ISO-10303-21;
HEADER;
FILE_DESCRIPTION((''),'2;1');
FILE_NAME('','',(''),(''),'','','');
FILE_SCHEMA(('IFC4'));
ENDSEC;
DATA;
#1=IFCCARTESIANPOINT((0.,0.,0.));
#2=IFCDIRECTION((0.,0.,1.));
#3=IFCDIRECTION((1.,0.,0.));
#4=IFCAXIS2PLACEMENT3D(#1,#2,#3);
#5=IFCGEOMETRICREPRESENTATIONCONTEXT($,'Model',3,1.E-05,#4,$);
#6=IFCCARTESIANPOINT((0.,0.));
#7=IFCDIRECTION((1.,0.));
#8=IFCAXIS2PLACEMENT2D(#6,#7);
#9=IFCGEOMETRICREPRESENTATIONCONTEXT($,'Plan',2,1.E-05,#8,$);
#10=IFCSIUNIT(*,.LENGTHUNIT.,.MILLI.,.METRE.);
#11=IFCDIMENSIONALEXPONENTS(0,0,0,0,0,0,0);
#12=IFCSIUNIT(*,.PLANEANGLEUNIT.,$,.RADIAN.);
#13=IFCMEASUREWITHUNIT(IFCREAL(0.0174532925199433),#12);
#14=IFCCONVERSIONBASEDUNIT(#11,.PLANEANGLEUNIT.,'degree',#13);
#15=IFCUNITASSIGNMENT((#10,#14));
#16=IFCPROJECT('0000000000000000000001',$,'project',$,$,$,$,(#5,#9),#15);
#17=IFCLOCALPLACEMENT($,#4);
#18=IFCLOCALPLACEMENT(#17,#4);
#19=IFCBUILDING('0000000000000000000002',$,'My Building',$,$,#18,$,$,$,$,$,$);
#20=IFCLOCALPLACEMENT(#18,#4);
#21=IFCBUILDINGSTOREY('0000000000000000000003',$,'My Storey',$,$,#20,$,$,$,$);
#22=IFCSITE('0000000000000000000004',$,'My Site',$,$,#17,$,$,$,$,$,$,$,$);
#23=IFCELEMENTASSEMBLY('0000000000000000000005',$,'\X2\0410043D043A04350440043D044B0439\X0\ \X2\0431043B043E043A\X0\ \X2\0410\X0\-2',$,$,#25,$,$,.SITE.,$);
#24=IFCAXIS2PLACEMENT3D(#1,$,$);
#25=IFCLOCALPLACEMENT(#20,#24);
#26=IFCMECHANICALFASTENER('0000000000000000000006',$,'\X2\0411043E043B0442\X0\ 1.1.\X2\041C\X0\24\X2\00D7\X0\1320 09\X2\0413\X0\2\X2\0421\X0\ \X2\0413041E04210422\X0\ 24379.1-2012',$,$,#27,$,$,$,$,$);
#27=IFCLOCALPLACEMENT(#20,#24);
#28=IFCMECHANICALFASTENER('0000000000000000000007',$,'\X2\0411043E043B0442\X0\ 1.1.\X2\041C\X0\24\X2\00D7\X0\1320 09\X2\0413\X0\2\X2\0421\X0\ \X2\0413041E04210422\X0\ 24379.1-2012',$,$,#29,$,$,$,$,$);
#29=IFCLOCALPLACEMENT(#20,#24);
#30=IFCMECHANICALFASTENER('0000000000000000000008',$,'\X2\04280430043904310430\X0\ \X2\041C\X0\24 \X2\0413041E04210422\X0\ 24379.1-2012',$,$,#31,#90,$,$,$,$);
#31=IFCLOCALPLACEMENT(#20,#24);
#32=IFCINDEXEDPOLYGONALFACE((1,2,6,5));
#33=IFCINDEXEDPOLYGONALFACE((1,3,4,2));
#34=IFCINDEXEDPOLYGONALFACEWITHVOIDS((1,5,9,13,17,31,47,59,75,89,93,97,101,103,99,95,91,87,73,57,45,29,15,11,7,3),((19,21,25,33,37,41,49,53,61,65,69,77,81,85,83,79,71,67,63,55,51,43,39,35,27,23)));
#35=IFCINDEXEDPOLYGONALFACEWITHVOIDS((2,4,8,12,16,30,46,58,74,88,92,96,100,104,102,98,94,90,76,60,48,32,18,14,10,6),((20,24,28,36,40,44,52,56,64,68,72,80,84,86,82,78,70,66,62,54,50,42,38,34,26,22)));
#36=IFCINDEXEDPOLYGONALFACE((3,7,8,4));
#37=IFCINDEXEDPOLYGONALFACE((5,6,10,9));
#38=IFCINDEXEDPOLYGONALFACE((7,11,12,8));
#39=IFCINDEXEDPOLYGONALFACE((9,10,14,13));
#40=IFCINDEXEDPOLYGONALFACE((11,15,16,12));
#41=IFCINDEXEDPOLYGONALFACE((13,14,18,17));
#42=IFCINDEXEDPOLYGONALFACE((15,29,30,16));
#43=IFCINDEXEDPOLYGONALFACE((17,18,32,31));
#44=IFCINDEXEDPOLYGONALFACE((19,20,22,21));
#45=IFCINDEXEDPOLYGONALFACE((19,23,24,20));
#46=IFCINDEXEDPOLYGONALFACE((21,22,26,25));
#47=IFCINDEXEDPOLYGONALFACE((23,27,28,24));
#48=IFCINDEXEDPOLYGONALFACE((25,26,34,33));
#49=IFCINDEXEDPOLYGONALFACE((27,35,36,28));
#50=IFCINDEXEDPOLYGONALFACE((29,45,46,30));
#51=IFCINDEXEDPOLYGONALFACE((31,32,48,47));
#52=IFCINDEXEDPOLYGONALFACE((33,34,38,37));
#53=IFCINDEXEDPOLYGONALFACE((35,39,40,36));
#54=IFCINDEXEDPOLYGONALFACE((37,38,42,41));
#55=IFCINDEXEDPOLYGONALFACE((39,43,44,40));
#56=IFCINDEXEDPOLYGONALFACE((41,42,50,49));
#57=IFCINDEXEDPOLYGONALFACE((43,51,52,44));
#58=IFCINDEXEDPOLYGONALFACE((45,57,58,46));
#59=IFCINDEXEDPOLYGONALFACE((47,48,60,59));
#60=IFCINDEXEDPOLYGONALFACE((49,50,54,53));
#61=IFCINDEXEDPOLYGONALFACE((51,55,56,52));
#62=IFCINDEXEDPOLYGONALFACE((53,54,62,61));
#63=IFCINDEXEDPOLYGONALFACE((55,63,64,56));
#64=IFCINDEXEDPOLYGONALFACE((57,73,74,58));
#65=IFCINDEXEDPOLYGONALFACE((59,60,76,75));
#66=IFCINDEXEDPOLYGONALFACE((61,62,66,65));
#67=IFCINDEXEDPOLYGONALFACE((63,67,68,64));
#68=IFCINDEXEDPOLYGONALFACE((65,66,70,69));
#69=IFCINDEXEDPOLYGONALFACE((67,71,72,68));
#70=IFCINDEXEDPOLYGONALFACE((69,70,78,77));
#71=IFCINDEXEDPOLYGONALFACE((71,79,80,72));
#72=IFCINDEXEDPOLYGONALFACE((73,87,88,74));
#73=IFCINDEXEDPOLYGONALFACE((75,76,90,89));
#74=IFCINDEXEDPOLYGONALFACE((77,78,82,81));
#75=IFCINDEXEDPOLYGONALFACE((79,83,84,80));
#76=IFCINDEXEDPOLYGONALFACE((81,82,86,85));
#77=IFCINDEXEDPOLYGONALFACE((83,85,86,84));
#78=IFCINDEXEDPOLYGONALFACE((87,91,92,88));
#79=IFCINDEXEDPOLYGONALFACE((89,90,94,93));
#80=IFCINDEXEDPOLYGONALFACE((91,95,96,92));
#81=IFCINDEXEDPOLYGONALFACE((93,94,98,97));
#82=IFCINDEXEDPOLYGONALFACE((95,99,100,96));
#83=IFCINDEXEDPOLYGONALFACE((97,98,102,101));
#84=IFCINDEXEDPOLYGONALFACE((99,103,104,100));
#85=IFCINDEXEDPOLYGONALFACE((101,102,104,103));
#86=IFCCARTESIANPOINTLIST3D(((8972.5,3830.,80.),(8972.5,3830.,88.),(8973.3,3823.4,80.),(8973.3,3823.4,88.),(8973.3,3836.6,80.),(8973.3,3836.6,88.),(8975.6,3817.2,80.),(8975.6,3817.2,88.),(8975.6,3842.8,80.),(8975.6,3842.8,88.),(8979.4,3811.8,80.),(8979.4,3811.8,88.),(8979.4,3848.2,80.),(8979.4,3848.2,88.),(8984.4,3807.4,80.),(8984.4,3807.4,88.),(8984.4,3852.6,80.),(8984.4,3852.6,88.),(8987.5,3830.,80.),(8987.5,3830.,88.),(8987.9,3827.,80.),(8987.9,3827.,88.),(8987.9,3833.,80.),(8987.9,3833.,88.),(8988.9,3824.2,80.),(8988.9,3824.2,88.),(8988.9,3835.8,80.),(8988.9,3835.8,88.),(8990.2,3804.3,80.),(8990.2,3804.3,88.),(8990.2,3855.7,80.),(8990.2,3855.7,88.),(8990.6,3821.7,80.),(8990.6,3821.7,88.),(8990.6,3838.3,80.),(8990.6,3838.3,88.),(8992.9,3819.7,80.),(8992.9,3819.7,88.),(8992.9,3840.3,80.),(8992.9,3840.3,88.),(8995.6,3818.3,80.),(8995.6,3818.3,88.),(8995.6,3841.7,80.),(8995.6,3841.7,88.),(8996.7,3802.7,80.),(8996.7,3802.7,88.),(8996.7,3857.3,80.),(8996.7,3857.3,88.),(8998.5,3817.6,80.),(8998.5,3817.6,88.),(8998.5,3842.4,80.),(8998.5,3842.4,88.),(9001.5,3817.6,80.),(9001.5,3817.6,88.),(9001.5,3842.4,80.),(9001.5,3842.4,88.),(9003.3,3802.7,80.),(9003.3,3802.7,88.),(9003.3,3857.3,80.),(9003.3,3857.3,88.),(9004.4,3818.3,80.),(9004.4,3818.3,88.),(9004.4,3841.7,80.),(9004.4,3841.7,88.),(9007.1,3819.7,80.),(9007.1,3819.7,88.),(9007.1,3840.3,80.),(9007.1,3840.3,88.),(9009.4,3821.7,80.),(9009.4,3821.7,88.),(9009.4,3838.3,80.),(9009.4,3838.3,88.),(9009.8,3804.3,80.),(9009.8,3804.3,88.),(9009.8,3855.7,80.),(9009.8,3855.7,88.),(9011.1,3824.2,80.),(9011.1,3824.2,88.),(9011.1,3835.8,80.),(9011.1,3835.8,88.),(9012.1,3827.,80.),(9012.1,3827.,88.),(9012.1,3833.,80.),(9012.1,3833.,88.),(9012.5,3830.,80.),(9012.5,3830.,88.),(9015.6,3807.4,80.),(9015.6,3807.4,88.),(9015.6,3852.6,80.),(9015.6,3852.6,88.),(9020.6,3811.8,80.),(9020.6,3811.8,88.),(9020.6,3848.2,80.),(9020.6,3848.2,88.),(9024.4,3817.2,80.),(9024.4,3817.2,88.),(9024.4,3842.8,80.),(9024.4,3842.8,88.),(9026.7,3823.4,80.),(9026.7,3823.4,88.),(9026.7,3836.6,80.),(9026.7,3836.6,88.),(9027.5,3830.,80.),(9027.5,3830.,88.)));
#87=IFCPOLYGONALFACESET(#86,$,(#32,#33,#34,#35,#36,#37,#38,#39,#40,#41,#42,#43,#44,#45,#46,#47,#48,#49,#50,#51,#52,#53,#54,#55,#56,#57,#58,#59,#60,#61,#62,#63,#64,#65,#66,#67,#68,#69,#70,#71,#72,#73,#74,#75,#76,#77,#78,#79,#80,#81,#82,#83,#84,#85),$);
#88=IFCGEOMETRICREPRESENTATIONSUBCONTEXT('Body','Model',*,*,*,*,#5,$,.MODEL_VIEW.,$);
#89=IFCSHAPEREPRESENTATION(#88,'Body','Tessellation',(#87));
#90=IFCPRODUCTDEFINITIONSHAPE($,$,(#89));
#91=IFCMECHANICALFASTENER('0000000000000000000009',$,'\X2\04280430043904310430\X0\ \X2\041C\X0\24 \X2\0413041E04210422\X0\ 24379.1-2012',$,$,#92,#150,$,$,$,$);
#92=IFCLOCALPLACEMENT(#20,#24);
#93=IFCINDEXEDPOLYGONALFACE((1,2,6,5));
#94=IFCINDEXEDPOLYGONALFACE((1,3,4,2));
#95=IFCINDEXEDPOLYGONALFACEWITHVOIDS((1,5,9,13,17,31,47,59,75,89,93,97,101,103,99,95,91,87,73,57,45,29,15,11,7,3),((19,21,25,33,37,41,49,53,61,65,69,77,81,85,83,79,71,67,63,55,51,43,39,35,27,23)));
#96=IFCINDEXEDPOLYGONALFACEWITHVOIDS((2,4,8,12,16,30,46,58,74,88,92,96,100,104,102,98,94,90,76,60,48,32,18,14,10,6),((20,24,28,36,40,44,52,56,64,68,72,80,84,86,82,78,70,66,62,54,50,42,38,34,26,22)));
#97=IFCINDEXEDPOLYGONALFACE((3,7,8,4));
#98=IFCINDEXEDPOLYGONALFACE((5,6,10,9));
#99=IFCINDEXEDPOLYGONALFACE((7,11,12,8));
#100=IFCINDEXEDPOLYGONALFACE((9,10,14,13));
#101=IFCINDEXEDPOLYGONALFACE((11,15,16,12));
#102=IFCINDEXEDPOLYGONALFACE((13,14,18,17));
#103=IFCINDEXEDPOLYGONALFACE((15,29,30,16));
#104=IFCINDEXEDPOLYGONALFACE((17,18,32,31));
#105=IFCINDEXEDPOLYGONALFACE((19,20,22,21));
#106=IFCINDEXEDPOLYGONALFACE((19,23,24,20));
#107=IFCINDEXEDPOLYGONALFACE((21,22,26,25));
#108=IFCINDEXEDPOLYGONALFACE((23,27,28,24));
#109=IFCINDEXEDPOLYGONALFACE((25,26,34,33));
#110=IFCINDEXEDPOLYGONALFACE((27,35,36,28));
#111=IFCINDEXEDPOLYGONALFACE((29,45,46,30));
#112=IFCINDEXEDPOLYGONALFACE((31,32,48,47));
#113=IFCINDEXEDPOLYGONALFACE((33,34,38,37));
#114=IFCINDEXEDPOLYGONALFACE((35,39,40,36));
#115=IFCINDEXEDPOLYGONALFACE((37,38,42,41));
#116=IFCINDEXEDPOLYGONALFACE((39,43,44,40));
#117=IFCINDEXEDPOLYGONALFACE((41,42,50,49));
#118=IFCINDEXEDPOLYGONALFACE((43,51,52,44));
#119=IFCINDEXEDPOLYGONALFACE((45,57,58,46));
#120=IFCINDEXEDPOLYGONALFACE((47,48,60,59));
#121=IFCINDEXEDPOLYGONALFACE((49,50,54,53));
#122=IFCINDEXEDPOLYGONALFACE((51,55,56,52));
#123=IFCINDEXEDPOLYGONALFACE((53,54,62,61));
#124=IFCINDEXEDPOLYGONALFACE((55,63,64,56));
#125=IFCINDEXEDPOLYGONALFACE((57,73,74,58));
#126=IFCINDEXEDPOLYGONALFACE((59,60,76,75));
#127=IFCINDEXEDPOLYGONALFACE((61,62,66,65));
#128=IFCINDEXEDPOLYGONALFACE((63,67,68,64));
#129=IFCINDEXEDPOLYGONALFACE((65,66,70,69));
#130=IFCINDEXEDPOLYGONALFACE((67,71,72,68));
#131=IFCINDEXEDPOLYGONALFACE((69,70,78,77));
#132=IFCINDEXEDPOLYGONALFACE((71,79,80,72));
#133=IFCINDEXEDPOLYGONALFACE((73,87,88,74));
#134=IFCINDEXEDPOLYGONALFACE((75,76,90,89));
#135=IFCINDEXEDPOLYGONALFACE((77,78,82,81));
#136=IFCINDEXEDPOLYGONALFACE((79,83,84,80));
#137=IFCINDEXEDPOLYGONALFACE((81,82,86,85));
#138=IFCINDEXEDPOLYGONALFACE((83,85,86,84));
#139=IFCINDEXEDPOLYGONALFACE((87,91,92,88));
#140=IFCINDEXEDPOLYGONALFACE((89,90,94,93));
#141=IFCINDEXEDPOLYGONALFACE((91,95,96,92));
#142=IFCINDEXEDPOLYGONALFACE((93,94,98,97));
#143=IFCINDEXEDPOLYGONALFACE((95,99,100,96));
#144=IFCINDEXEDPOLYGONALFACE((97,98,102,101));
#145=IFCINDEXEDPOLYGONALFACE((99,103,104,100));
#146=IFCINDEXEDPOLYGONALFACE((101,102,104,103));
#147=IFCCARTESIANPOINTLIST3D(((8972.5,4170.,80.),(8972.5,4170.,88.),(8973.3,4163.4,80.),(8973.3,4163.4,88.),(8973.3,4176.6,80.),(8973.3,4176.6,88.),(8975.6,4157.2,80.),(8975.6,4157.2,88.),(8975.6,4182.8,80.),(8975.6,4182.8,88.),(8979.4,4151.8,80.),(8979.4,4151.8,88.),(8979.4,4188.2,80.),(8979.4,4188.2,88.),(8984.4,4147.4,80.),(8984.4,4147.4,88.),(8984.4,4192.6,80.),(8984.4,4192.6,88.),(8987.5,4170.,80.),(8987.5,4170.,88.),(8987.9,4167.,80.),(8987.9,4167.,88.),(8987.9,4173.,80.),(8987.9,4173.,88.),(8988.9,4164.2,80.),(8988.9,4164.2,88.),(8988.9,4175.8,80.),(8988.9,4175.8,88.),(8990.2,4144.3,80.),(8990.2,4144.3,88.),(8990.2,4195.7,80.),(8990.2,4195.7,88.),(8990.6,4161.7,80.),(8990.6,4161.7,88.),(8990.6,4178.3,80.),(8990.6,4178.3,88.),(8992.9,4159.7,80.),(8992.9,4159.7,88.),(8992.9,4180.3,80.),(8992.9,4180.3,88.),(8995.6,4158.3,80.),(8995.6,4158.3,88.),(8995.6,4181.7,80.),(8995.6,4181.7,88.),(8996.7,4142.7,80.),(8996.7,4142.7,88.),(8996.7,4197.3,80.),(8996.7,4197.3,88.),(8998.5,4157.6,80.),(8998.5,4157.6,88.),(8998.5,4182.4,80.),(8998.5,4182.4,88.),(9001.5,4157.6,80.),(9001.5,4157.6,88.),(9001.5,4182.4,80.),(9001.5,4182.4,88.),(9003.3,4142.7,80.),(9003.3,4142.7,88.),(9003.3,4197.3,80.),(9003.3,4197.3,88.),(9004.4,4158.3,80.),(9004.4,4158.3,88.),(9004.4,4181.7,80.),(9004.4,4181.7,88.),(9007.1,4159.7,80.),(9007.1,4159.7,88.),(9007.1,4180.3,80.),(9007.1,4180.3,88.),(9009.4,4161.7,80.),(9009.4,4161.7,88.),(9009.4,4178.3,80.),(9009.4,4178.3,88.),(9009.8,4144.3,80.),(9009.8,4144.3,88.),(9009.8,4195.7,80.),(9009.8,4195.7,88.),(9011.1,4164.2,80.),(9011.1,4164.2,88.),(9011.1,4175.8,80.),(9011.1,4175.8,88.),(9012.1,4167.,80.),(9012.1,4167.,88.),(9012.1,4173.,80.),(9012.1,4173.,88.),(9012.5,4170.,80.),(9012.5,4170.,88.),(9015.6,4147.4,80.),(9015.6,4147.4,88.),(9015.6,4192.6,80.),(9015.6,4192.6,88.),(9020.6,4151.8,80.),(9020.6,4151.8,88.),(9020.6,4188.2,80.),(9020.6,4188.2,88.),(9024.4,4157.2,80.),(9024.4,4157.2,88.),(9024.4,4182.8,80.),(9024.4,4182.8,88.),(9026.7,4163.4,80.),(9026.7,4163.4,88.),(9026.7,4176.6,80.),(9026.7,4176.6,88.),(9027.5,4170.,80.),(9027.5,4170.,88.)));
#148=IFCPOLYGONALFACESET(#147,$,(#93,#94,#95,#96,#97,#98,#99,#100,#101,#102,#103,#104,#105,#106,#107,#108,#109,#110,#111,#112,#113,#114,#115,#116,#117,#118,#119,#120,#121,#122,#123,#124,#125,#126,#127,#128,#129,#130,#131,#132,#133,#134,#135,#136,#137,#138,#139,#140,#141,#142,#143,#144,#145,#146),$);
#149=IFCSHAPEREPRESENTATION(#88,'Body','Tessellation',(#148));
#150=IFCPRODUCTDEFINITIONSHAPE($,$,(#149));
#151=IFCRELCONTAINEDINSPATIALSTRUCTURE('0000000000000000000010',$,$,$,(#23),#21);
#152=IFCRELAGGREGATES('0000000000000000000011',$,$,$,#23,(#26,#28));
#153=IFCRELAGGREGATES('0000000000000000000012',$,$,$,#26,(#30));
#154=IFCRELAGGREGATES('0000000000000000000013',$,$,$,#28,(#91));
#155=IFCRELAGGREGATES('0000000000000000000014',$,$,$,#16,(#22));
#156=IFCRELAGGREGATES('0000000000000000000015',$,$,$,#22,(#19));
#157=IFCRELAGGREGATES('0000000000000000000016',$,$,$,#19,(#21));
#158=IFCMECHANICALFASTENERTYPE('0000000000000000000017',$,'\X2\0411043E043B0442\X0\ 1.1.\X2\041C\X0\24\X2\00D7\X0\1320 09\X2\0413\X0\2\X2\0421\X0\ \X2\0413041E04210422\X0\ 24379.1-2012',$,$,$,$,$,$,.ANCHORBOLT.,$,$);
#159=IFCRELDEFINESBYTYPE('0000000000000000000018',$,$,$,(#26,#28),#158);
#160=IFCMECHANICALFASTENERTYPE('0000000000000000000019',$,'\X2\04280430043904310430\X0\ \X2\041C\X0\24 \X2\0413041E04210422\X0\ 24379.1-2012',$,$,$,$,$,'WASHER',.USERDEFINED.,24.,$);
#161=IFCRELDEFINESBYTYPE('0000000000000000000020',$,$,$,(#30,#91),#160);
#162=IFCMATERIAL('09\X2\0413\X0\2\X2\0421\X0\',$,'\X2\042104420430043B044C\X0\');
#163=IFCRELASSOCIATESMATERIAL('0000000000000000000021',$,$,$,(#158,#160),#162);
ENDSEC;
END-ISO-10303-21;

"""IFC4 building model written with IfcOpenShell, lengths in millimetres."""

from ifc_helpers import new_model, entity, si_unit, converted_unit, frame, origin_with_axes, origin_2d_with_axis, place, context, subcontext, project, spatial, polyline, outline, extrude, source, transform, mapped, material, type_object, type_shapes, element, aggregate, save


model = new_model("IFC4")

# Units and contexts
model_context = context("Model", 3, precision=1e-05, world=origin_with_axes())
plan_context = context("Plan", 2, precision=1e-05, world=origin_2d_with_axis())
body_context = subcontext(model_context, "Body", "Model", "MODEL_VIEW")
ifc_project = project(units=[si_unit("LENGTHUNIT", "METRE", prefix="MILLI"), converted_unit("PLANEANGLEUNIT", "degree", entity("IfcReal", 0.0174532925199433), si_unit("PLANEANGLEUNIT", "RADIAN"), dimensions=[0, 0, 0, 0, 0, 0, 0])], contexts=[model_context, plan_context])

# Site, building, storey
site_placement = place(None, origin_with_axes())
site = spatial("IfcSite", under=ifc_project, at=site_placement, Name="My Site")
building_placement = place(site_placement, origin_with_axes())
building = spatial("IfcBuilding", under=site, at=building_placement, Name="My Building")
storey_placement = place(building_placement, origin_with_axes())
storey = spatial("IfcBuildingStorey", under=building, at=storey_placement, Name="My Storey")

# Element assembly, mechanical fasteners
ifc_material_1 = material(Name="09Г2С", Category="Сталь")
mechanical_fastener_type_1 = type_object("IfcMechanicalFastenerType", Name="Болт 1.1.М24×1320 09Г2С ГОСТ 24379.1-2012", PredefinedType="ANCHORBOLT", material=ifc_material_1)
assembly_1_placement = place(storey_placement, frame((9000.0, 4000.0, 0.0), z_axis=(0.0, 0.0, 1.0), x_axis=(1.0, 0.0, 0.0)))
assembly_1 = element("IfcElementAssembly", 1, at=assembly_1_placement, inside=storey, Name="Анкерный блок А-2", AssemblyPlace="SITE")
mechanical_fastener_1_placement = place(assembly_1_placement, frame((0.0, -170.0, 0.0), z_axis=(0.0, 0.0, 1.0), x_axis=(1.0, 0.0, 0.0)))
mechanical_fastener_1 = element("IfcMechanicalFastener", 2, at=mechanical_fastener_1_placement, type_object=mechanical_fastener_type_1, Name="Болт 1.1.М24×1320 09Г2С ГОСТ 24379.1-2012")
mechanical_fastener_2_placement = place(assembly_1_placement, frame((0.0, 170.0, 0.0), z_axis=(0.0, 0.0, 1.0), x_axis=(-1.0, 0.0, 0.0)))
mechanical_fastener_2 = element("IfcMechanicalFastener", 3, at=mechanical_fastener_2_placement, type_object=mechanical_fastener_type_1, Name="Болт 1.1.М24×1320 09Г2С ГОСТ 24379.1-2012")
aggregate(assembly_1, [mechanical_fastener_1, mechanical_fastener_2])

# Mechanical fasteners
mechanical_fastener_type_2 = type_object("IfcMechanicalFastenerType", Name="Шайба М24 ГОСТ 24379.1-2012", ElementType="WASHER", NominalDiameter=24.0, PredefinedType="USERDEFINED", material=ifc_material_1)
shared_shape_1 = source(origin_with_axes(), body_context, "Body", "SweptSolid", [
    extrude(outline(polyline([(27.5, 0.0), (26.7, 6.6), (24.4, 12.8), (20.6, 18.2), (15.6, 22.6), (9.8, 25.7), (3.3, 27.3), (-3.3, 27.3), (-9.8, 25.7), (-15.6, 22.6), (-20.6, 18.2), (-24.4, 12.8), (-26.7, 6.6), (-27.5, 0.0), (-26.7, -6.6), (-24.4, -12.8), (-20.6, -18.2), (-15.6, -22.6), (-9.8, -25.7), (-3.3, -27.3), (3.3, -27.3), (9.8, -25.7), (15.6, -22.6), (20.6, -18.2), (24.4, -12.8), (26.7, -6.6), (27.5, 0.0)]), holes=[polyline([(-4.4, -11.7), (-7.1, -10.3), (-9.4, -8.3), (-11.1, -5.8), (-12.1, -3.0), (-12.5, 0.0), (-12.1, 3.0), (-11.1, 5.8), (-9.4, 8.3), (-7.1, 10.3), (-4.4, 11.7), (-1.5, 12.4), (1.5, 12.4), (4.4, 11.7), (7.1, 10.3), (9.4, 8.3), (11.1, 5.8), (12.1, 3.0), (12.5, 0.0), (12.1, -3.0), (11.1, -5.8), (9.4, -8.3), (7.1, -10.3), (4.4, -11.7), (1.5, -12.4), (-1.5, -12.4), (-4.4, -11.7)])]), frame((0.0, 0.0, 0.0), z_axis=(0.0, 0.0, 1.0), x_axis=(0.120537, -0.992709, 0.0)), (0.0, 0.0, 1.0), 8.0),
])
type_shapes(mechanical_fastener_type_2, [shared_shape_1])
mechanical_fastener_3_placement = place(mechanical_fastener_1_placement, frame((0.0, 0.0, 80.0), z_axis=(0.0, 0.0, 1.0), x_axis=(1.0, 0.0, 0.0)))
mechanical_fastener_3 = element("IfcMechanicalFastener", 4, at=mechanical_fastener_3_placement, type_object=mechanical_fastener_type_2, Name="Шайба М24 ГОСТ 24379.1-2012", context=body_context, shape_type="MappedRepresentation", body=[
    mapped(shared_shape_1, transform((0.0, 0.0, 0.0), x_axis=(1.0, 0.0, 0.0), y_axis=(0.0, 1.0, 0.0), z_axis=(0.0, 0.0, 1.0), scale=1.0)),
])
aggregate(mechanical_fastener_1, [mechanical_fastener_3])
mechanical_fastener_4_placement = place(mechanical_fastener_2_placement, frame((0.0, 0.0, 80.0), z_axis=(0.0, 0.0, 1.0), x_axis=(1.0, 0.0, 0.0)))
mechanical_fastener_4 = element("IfcMechanicalFastener", 5, at=mechanical_fastener_4_placement, type_object=mechanical_fastener_type_2, Name="Шайба М24 ГОСТ 24379.1-2012", context=body_context, shape_type="MappedRepresentation", body=[
    mapped(shared_shape_1, transform((0.0, 0.0, 0.0), x_axis=(1.0, 0.0, 0.0), y_axis=(0.0, 1.0, 0.0), z_axis=(0.0, 0.0, 1.0), scale=1.0)),
])
aggregate(mechanical_fastener_2, [mechanical_fastener_4])

save(model, "model.ifc")
